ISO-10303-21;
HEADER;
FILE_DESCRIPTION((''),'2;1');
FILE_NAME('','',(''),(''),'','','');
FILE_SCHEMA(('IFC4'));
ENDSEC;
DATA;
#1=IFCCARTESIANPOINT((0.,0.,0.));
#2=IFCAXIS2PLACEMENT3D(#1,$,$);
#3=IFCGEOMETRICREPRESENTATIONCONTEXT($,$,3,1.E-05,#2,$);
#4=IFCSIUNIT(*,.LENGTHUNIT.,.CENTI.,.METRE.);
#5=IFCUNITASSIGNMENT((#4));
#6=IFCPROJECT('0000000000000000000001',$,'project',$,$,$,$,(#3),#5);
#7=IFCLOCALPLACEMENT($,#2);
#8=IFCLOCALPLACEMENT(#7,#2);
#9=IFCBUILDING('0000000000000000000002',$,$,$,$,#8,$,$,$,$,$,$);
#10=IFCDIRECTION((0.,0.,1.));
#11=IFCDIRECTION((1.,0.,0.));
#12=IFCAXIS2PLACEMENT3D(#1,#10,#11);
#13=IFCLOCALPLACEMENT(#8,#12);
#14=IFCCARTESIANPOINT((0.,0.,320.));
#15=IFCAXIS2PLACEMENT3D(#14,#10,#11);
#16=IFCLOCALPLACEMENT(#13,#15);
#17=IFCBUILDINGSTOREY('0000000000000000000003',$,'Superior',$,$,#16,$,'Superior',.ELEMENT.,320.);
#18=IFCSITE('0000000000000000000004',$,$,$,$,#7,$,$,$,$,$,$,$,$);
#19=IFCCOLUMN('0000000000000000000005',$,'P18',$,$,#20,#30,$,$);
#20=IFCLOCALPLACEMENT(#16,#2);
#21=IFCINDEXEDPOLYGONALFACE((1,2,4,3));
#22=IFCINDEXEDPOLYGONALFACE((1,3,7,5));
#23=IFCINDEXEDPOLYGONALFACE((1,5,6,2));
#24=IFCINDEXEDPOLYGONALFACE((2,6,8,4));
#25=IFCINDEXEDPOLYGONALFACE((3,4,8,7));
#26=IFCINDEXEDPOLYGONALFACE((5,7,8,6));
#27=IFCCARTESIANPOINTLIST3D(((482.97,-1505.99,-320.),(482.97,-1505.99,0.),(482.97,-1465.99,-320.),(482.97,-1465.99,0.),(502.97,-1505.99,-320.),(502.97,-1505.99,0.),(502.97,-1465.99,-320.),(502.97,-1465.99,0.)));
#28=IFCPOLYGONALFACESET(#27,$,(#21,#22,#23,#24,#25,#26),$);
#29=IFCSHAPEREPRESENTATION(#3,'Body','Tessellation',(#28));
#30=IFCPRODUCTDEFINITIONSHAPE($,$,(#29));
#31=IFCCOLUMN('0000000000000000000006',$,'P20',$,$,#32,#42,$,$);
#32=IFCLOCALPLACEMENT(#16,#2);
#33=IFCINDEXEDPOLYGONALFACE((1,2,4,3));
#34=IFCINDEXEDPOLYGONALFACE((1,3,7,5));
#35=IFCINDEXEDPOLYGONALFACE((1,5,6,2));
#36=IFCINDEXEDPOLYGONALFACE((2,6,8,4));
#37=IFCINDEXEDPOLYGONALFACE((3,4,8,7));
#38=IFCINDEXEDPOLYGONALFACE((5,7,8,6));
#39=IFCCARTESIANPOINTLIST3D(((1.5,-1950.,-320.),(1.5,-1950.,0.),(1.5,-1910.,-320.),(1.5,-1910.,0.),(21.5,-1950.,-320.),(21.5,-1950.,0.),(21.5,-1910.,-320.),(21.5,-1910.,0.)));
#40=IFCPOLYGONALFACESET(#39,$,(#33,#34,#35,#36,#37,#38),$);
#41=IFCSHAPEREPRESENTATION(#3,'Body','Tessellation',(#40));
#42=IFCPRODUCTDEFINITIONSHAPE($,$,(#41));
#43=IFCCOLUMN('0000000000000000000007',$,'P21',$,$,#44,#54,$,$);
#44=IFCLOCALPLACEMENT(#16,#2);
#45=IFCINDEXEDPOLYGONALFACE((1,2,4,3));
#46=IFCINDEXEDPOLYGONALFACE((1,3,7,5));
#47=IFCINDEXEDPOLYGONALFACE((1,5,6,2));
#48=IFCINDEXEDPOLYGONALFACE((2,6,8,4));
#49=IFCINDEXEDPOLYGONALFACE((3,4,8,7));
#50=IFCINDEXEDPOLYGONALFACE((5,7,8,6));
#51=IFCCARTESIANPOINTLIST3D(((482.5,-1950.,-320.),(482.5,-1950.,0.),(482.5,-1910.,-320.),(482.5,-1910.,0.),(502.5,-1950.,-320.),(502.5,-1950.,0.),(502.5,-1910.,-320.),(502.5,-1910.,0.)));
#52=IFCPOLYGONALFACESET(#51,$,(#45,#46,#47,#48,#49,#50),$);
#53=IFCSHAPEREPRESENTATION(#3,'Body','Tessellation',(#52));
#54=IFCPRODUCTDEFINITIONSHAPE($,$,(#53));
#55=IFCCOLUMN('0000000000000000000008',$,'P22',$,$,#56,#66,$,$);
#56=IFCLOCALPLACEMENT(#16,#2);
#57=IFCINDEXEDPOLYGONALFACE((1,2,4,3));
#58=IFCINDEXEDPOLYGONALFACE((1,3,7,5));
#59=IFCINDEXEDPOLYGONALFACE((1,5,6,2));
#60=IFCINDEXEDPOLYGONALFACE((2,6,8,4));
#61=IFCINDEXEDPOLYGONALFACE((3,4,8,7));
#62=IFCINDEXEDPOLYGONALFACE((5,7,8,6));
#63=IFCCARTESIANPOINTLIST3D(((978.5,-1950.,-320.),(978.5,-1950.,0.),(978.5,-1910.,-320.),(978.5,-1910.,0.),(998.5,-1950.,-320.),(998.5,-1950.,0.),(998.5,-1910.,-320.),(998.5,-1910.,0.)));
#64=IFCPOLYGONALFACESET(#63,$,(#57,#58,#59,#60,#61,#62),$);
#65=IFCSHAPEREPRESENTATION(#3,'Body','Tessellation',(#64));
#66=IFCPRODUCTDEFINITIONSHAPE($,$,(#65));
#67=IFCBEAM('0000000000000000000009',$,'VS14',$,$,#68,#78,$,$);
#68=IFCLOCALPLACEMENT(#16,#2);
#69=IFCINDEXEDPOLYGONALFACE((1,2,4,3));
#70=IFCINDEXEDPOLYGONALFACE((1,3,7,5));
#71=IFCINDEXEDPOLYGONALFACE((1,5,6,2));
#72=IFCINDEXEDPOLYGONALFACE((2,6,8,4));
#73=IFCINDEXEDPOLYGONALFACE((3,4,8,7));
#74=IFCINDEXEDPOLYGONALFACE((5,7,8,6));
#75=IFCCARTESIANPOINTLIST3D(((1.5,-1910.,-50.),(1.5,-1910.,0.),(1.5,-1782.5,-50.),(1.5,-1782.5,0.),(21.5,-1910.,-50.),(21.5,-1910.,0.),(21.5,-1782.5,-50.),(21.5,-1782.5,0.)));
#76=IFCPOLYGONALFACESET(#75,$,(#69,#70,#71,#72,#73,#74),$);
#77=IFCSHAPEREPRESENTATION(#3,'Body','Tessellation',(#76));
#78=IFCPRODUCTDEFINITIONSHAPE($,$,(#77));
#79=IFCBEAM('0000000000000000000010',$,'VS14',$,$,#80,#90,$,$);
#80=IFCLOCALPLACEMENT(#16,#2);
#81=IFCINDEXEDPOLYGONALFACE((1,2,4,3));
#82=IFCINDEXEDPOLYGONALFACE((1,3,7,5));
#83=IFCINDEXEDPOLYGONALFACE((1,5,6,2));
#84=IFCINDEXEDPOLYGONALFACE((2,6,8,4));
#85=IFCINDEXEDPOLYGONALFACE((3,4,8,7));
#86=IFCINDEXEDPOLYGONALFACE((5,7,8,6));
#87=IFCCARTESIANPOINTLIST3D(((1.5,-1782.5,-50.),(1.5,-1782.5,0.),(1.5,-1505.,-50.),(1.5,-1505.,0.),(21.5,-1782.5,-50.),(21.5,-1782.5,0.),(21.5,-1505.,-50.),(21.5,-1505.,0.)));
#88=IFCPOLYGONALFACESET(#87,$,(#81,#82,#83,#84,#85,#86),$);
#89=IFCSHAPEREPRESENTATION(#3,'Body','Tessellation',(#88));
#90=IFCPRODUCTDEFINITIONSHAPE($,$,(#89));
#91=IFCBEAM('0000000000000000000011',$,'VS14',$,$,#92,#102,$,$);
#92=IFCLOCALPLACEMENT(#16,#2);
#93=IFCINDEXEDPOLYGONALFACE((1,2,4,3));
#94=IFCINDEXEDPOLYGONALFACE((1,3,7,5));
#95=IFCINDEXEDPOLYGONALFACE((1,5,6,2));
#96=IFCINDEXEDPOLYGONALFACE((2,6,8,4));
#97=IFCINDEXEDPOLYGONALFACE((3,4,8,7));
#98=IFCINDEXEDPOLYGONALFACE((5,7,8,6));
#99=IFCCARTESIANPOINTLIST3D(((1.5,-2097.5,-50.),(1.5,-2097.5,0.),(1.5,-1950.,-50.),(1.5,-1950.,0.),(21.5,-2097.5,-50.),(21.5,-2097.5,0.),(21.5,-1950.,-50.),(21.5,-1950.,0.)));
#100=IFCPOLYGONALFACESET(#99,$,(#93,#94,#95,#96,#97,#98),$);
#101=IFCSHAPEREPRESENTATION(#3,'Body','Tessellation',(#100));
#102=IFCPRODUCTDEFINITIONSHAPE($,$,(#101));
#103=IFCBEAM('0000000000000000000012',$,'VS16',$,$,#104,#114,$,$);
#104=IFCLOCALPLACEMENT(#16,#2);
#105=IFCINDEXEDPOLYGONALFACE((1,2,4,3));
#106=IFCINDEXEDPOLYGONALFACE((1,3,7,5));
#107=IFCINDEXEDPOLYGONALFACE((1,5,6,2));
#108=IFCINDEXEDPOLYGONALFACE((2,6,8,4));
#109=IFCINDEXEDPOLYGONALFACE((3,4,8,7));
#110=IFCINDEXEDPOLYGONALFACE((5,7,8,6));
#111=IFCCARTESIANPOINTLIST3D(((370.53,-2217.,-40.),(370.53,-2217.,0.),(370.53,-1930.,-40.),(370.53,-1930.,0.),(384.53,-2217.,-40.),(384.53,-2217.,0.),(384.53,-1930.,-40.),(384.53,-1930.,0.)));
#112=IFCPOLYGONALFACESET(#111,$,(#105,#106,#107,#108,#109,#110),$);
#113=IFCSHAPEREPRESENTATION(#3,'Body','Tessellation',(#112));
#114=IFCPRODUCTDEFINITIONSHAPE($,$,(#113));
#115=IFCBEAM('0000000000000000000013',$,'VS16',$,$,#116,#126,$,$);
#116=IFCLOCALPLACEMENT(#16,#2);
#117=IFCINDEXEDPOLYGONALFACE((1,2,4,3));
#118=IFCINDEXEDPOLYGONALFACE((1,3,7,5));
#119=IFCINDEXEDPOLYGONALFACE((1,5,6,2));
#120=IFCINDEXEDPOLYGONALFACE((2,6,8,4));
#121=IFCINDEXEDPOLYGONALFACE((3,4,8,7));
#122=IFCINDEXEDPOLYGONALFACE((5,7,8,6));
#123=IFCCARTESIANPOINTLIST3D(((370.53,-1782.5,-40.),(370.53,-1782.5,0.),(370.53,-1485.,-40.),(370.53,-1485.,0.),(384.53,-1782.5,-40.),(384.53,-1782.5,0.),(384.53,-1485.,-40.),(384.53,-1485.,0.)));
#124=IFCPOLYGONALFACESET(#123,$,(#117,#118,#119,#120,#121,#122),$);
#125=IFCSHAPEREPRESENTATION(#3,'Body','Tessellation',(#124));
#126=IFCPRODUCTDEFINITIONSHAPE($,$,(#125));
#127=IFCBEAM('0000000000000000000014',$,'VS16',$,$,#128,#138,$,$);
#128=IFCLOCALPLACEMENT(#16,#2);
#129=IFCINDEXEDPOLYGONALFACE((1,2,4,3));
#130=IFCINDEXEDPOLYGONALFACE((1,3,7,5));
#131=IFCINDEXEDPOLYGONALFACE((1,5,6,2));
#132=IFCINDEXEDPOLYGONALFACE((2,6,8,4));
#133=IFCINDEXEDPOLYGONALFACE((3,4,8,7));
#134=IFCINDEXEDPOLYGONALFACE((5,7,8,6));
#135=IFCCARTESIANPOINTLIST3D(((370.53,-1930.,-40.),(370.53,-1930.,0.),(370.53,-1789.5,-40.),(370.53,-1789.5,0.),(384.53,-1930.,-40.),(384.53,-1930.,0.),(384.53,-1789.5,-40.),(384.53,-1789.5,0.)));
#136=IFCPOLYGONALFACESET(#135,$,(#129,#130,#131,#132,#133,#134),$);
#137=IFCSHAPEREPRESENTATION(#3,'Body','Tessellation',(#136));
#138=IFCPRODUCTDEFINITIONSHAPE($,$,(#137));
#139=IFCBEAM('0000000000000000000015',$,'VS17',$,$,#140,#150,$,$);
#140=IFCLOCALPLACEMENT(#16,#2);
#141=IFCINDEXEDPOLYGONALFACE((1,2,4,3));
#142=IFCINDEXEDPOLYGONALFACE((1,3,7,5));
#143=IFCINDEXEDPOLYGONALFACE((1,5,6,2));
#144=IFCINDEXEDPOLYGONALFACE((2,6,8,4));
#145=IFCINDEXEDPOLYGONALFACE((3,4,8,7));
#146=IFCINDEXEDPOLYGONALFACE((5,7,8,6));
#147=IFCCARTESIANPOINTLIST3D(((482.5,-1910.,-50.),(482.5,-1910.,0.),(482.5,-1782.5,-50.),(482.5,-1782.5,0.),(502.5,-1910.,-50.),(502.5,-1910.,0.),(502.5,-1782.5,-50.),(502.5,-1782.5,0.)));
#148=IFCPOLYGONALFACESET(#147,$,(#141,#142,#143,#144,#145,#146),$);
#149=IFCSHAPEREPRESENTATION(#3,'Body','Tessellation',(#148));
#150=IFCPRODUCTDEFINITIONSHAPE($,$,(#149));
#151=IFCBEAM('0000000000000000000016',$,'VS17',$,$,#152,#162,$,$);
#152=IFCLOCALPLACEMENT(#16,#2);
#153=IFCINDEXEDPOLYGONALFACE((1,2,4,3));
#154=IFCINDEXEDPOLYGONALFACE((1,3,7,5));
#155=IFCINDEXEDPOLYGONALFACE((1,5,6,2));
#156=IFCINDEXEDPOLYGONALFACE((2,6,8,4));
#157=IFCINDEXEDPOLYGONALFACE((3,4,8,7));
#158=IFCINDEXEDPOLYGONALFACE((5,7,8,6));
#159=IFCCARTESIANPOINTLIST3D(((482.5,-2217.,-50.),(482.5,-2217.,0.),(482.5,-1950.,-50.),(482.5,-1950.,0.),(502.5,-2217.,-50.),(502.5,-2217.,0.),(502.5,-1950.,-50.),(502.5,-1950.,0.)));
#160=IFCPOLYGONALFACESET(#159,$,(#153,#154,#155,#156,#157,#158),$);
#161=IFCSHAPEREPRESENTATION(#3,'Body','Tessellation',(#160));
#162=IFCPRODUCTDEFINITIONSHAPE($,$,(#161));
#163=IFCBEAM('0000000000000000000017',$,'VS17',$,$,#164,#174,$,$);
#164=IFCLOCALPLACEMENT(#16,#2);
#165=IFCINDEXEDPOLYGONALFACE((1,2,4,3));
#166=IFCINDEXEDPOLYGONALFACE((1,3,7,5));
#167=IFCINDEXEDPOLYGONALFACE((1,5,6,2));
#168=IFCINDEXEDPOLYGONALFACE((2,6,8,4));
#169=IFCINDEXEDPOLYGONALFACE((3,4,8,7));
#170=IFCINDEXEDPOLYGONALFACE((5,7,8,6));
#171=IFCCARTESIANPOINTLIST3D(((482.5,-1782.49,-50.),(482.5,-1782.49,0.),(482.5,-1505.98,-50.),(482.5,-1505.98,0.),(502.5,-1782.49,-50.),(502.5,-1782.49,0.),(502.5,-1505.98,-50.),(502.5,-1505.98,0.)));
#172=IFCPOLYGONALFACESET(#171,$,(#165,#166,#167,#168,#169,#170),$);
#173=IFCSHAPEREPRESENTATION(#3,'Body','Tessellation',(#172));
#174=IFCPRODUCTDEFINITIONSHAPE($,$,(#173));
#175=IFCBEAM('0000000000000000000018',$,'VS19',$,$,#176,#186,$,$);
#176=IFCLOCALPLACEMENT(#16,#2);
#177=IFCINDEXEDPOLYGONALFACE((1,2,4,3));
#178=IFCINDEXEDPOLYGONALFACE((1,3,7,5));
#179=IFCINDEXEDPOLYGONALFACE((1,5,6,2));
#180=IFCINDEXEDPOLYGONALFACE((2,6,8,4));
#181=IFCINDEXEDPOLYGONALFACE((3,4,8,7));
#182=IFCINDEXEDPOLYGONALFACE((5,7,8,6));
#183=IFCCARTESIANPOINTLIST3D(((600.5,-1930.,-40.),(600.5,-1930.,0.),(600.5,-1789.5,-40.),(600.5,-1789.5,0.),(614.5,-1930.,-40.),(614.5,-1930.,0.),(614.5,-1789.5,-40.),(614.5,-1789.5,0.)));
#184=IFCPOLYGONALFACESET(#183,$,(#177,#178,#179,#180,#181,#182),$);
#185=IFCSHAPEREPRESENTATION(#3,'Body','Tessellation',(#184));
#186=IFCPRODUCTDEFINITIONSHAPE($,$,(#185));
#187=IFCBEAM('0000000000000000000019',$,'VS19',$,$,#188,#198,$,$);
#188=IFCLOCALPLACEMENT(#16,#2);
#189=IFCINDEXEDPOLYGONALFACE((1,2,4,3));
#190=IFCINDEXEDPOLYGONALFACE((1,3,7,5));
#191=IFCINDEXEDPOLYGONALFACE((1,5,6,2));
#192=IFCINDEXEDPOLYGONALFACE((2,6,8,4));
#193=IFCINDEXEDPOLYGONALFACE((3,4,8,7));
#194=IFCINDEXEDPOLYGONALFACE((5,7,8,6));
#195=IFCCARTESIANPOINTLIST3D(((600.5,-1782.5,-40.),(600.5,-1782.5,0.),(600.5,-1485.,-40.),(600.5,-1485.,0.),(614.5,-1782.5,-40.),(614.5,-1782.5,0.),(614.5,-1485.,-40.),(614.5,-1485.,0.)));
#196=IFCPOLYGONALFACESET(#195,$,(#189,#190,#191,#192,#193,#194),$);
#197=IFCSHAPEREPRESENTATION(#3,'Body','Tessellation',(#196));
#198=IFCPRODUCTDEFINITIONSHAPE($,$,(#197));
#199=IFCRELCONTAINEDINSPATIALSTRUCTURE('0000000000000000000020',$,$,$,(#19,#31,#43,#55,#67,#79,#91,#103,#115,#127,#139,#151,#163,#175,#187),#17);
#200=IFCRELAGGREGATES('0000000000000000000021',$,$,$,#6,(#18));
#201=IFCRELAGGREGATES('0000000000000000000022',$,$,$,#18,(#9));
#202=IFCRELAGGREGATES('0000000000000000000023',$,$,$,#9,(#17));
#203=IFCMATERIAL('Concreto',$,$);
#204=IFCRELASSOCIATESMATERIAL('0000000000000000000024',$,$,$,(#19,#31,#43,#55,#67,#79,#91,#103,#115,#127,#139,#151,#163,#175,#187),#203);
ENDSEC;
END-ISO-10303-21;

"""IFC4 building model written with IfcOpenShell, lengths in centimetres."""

from ifc_helpers import new_model, si_unit, frame, origin, origin_with_axes, place, context, project, spatial, polyline, outline, extrude, material, element, save


model = new_model("IFC4")

# Units and contexts
context_of_model = context(None, 3, precision=1e-05, world=origin())
ifc_project = project(units=[si_unit("LENGTHUNIT", "METRE", prefix="CENTI")], contexts=[context_of_model])

# Site, building, storey
site_placement = place(None, origin())
site = spatial("IfcSite", under=ifc_project, at=site_placement)
building_placement = place(site_placement, origin())
building = spatial("IfcBuilding", under=site, at=building_placement)
placement = place(building_placement, origin_with_axes())
storey_placement = place(placement, frame((0.0, 0.0, 320.0), z_axis=(0.0, 0.0, 1.0), x_axis=(1.0, 0.0, 0.0)))
storey = spatial("IfcBuildingStorey", under=building, at=storey_placement, Name="Superior", LongName="Superior", CompositionType="ELEMENT", Elevation=320.0)

# Columns
ifc_material = material(Name="Concreto")
column_1_placement = place(storey_placement, frame((492.97, -1485.99, 0.0), z_axis=(0.0, 0.0, 1.0), x_axis=(1.0, 0.0, 0.0)))
element("IfcColumn", 1, at=column_1_placement, inside=storey, material=ifc_material, Name="P18", context=context_of_model, shape_type="SolidModel", body=[
    extrude(outline(polyline([(-10.0, -20.0), (10.0, -20.0), (10.0, 20.0), (-10.0, 20.0), (-10.0, -20.0)])), origin_with_axes(), (0.0, 0.0, -1.0), 320.0),
])
column_2_placement = place(storey_placement, frame((11.5, -1930.0, 0.0), z_axis=(0.0, 0.0, 1.0), x_axis=(1.0, 0.0, 0.0)))
element("IfcColumn", 2, at=column_2_placement, inside=storey, material=ifc_material, Name="P20", context=context_of_model, shape_type="SolidModel", body=[
    extrude(outline(polyline([(-10.0, -20.0), (10.0, -20.0), (10.0, 20.0), (-10.0, 20.0), (-10.0, -20.0)])), frame((0.0, 0.0, 0.0), z_axis=(0.0, 0.0, 1.0), x_axis=(1.0, 0.0, 0.0)), (0.0, 0.0, -1.0), 320.0),
])
column_3_placement = place(storey_placement, frame((492.5, -1930.0, 0.0), z_axis=(0.0, 0.0, 1.0), x_axis=(1.0, 0.0, 0.0)))
element("IfcColumn", 3, at=column_3_placement, inside=storey, material=ifc_material, Name="P21", context=context_of_model, shape_type="SolidModel", body=[
    extrude(outline(polyline([(-10.0, -20.0), (10.0, -20.0), (10.0, 20.0), (-10.0, 20.0), (-10.0, -20.0)])), origin_with_axes(), (0.0, 0.0, -1.0), 320.0),
])
column_4_placement = place(storey_placement, frame((988.5, -1930.0, 0.0), z_axis=(0.0, 0.0, 1.0), x_axis=(1.0, 0.0, 0.0)))
element("IfcColumn", 4, at=column_4_placement, inside=storey, material=ifc_material, Name="P22", context=context_of_model, shape_type="SolidModel", body=[
    extrude(outline(polyline([(10.0, 20.0), (-10.0, 20.0), (-10.0, -20.0), (10.0, -20.0), (10.0, 20.0)])), origin_with_axes(), (0.0, 0.0, -1.0), 320.0),
])

# Beams
beam_1_placement = place(storey_placement, frame((11.5, -1846.25, 0.0), z_axis=(0.0, 0.0, 1.0), x_axis=(1.0, 0.0, 0.0)))
element("IfcBeam", 5, at=beam_1_placement, inside=storey, material=ifc_material, Name="VS14", context=context_of_model, shape_type="SolidModel", body=[
    extrude(outline(polyline([(-10.0, -25.0), (10.0, -25.0), (10.0, 25.0), (-10.0, 25.0), (-10.0, -25.0)])), frame((0.0, -63.75, -25.0), z_axis=(0.0, 1.0, 0.0), x_axis=(1.0, 0.0, 0.0)), (0.0, 0.0, 1.0), 127.5),
])
beam_2_placement = place(storey_placement, frame((11.5, -1643.75, 0.0), z_axis=(0.0, 0.0, 1.0), x_axis=(1.0, 0.0, 0.0)))
element("IfcBeam", 6, at=beam_2_placement, inside=storey, material=ifc_material, Name="VS14", context=context_of_model, shape_type="SolidModel", body=[
    extrude(outline(polyline([(-10.0, -25.0), (10.0, -25.0), (10.0, 25.0), (-10.0, 25.0), (-10.0, -25.0)])), frame((0.0, -138.75, -25.0), z_axis=(0.0, 1.0, 0.0), x_axis=(1.0, 0.0, 0.0)), (0.0, 0.0, 1.0), 277.5),
])
beam_3_placement = place(storey_placement, frame((11.5, -2023.75, 0.0), z_axis=(0.0, 0.0, 1.0), x_axis=(1.0, 0.0, 0.0)))
element("IfcBeam", 7, at=beam_3_placement, inside=storey, material=ifc_material, Name="VS14", context=context_of_model, shape_type="SolidModel", body=[
    extrude(outline(polyline([(-10.0, -25.0), (10.0, -25.0), (10.0, 25.0), (-10.0, 25.0), (-10.0, -25.0)])), frame((0.0, -73.75, -25.0), z_axis=(0.0, 1.0, 0.0), x_axis=(1.0, 0.0, 0.0)), (0.0, 0.0, 1.0), 147.5),
])
beam_4_placement = place(storey_placement, frame((377.53, -2073.5, 0.0), z_axis=(0.0, 0.0, 1.0), x_axis=(1.0, 0.0, 0.0)))
element("IfcBeam", 8, at=beam_4_placement, inside=storey, material=ifc_material, Name="VS16", context=context_of_model, shape_type="SolidModel", body=[
    extrude(outline(polyline([(-7.0, -20.0), (7.0, -20.0), (7.0, 20.0), (-7.0, 20.0), (-7.0, -20.0)])), frame((0.0, -143.5, -20.0), z_axis=(0.0, 1.0, 0.0), x_axis=(1.0, 0.0, 0.0)), (0.0, 0.0, 1.0), 287.0),
])
beam_5_placement = place(storey_placement, frame((377.53, -1633.75, 0.0), z_axis=(0.0, 0.0, 1.0), x_axis=(1.0, 0.0, 0.0)))
element("IfcBeam", 9, at=beam_5_placement, inside=storey, material=ifc_material, Name="VS16", context=context_of_model, shape_type="SolidModel", body=[
    extrude(outline(polyline([(-7.0, -20.0), (7.0, -20.0), (7.0, 20.0), (-7.0, 20.0), (-7.0, -20.0)])), frame((0.0, -148.75, -20.0), z_axis=(0.0, 1.0, 0.0), x_axis=(1.0, 0.0, 0.0)), (0.0, 0.0, 1.0), 297.5),
])
beam_6_placement = place(storey_placement, frame((377.53, -1859.75, 0.0), z_axis=(0.0, 0.0, 1.0), x_axis=(1.0, 0.0, 0.0)))
element("IfcBeam", 10, at=beam_6_placement, inside=storey, material=ifc_material, Name="VS16", context=context_of_model, shape_type="SolidModel", body=[
    extrude(outline(polyline([(-7.0, -20.0), (7.0, -20.0), (7.0, 20.0), (-7.0, 20.0), (-7.0, -20.0)])), frame((0.0, -70.25, -20.0), z_axis=(0.0, 1.0, 0.0), x_axis=(1.0, 0.0, 0.0)), (0.0, 0.0, 1.0), 140.5),
])
beam_7_placement = place(storey_placement, frame((492.5, -1846.25, 0.0), z_axis=(0.0, 0.0, 1.0), x_axis=(1.0, 0.0, 0.0)))
element("IfcBeam", 11, at=beam_7_placement, inside=storey, material=ifc_material, Name="VS17", context=context_of_model, shape_type="SolidModel", body=[
    extrude(outline(polyline([(-10.0, -25.0), (10.0, -25.0), (10.0, 25.0), (-10.0, 25.0), (-10.0, -25.0)])), frame((0.0, -63.75, -25.0), z_axis=(0.0, 1.0, 0.0), x_axis=(1.0, 0.0, 0.0)), (0.0, 0.0, 1.0), 127.5),
])
beam_8_placement = place(storey_placement, frame((492.5, -2083.5, 0.0), z_axis=(0.0, 0.0, 1.0), x_axis=(1.0, 0.0, 0.0)))
element("IfcBeam", 12, at=beam_8_placement, inside=storey, material=ifc_material, Name="VS17", context=context_of_model, shape_type="SolidModel", body=[
    extrude(outline(polyline([(-10.0, -25.0), (10.0, -25.0), (10.0, 25.0), (-10.0, 25.0), (-10.0, -25.0)])), frame((0.0, -133.5, -25.0), z_axis=(0.0, 1.0, 0.0), x_axis=(1.0, 0.0, 0.0)), (0.0, 0.0, 1.0), 267.0),
])
beam_9_placement = place(storey_placement, frame((492.5, -1644.24, 0.0), z_axis=(0.0, 0.0, 1.0), x_axis=(1.0, 0.0, 0.0)))
element("IfcBeam", 13, at=beam_9_placement, inside=storey, material=ifc_material, Name="VS17", context=context_of_model, shape_type="SolidModel", body=[
    extrude(outline(polyline([(-10.0, -25.0), (10.0, -25.0), (10.0, 25.0), (-10.0, 25.0), (-10.0, -25.0)])), frame((0.0, -138.25, -25.0), z_axis=(0.0, 1.0, 0.0), x_axis=(1.0, 0.0, 0.0)), (0.0, 0.0, 1.0), 276.51),
])
beam_10_placement = place(storey_placement, frame((607.5, -1859.75, 0.0), z_axis=(0.0, 0.0, 1.0), x_axis=(1.0, 0.0, 0.0)))
element("IfcBeam", 14, at=beam_10_placement, inside=storey, material=ifc_material, Name="VS19", context=context_of_model, shape_type="SolidModel", body=[
    extrude(outline(polyline([(-7.0, -20.0), (7.0, -20.0), (7.0, 20.0), (-7.0, 20.0), (-7.0, -20.0)])), frame((0.0, -70.25, -20.0), z_axis=(0.0, 1.0, 0.0), x_axis=(1.0, 0.0, 0.0)), (0.0, 0.0, 1.0), 140.5),
])
beam_11_placement = place(storey_placement, frame((607.5, -1633.75, 0.0), z_axis=(0.0, 0.0, 1.0), x_axis=(1.0, 0.0, 0.0)))
element("IfcBeam", 15, at=beam_11_placement, inside=storey, material=ifc_material, Name="VS19", context=context_of_model, shape_type="SolidModel", body=[
    extrude(outline(polyline([(-7.0, -20.0), (7.0, -20.0), (7.0, 20.0), (-7.0, 20.0), (-7.0, -20.0)])), frame((0.0, -148.75, -20.0), z_axis=(0.0, 1.0, 0.0), x_axis=(1.0, 0.0, 0.0)), (0.0, 0.0, 1.0), 297.5),
])

save(model, "model.ifc")
